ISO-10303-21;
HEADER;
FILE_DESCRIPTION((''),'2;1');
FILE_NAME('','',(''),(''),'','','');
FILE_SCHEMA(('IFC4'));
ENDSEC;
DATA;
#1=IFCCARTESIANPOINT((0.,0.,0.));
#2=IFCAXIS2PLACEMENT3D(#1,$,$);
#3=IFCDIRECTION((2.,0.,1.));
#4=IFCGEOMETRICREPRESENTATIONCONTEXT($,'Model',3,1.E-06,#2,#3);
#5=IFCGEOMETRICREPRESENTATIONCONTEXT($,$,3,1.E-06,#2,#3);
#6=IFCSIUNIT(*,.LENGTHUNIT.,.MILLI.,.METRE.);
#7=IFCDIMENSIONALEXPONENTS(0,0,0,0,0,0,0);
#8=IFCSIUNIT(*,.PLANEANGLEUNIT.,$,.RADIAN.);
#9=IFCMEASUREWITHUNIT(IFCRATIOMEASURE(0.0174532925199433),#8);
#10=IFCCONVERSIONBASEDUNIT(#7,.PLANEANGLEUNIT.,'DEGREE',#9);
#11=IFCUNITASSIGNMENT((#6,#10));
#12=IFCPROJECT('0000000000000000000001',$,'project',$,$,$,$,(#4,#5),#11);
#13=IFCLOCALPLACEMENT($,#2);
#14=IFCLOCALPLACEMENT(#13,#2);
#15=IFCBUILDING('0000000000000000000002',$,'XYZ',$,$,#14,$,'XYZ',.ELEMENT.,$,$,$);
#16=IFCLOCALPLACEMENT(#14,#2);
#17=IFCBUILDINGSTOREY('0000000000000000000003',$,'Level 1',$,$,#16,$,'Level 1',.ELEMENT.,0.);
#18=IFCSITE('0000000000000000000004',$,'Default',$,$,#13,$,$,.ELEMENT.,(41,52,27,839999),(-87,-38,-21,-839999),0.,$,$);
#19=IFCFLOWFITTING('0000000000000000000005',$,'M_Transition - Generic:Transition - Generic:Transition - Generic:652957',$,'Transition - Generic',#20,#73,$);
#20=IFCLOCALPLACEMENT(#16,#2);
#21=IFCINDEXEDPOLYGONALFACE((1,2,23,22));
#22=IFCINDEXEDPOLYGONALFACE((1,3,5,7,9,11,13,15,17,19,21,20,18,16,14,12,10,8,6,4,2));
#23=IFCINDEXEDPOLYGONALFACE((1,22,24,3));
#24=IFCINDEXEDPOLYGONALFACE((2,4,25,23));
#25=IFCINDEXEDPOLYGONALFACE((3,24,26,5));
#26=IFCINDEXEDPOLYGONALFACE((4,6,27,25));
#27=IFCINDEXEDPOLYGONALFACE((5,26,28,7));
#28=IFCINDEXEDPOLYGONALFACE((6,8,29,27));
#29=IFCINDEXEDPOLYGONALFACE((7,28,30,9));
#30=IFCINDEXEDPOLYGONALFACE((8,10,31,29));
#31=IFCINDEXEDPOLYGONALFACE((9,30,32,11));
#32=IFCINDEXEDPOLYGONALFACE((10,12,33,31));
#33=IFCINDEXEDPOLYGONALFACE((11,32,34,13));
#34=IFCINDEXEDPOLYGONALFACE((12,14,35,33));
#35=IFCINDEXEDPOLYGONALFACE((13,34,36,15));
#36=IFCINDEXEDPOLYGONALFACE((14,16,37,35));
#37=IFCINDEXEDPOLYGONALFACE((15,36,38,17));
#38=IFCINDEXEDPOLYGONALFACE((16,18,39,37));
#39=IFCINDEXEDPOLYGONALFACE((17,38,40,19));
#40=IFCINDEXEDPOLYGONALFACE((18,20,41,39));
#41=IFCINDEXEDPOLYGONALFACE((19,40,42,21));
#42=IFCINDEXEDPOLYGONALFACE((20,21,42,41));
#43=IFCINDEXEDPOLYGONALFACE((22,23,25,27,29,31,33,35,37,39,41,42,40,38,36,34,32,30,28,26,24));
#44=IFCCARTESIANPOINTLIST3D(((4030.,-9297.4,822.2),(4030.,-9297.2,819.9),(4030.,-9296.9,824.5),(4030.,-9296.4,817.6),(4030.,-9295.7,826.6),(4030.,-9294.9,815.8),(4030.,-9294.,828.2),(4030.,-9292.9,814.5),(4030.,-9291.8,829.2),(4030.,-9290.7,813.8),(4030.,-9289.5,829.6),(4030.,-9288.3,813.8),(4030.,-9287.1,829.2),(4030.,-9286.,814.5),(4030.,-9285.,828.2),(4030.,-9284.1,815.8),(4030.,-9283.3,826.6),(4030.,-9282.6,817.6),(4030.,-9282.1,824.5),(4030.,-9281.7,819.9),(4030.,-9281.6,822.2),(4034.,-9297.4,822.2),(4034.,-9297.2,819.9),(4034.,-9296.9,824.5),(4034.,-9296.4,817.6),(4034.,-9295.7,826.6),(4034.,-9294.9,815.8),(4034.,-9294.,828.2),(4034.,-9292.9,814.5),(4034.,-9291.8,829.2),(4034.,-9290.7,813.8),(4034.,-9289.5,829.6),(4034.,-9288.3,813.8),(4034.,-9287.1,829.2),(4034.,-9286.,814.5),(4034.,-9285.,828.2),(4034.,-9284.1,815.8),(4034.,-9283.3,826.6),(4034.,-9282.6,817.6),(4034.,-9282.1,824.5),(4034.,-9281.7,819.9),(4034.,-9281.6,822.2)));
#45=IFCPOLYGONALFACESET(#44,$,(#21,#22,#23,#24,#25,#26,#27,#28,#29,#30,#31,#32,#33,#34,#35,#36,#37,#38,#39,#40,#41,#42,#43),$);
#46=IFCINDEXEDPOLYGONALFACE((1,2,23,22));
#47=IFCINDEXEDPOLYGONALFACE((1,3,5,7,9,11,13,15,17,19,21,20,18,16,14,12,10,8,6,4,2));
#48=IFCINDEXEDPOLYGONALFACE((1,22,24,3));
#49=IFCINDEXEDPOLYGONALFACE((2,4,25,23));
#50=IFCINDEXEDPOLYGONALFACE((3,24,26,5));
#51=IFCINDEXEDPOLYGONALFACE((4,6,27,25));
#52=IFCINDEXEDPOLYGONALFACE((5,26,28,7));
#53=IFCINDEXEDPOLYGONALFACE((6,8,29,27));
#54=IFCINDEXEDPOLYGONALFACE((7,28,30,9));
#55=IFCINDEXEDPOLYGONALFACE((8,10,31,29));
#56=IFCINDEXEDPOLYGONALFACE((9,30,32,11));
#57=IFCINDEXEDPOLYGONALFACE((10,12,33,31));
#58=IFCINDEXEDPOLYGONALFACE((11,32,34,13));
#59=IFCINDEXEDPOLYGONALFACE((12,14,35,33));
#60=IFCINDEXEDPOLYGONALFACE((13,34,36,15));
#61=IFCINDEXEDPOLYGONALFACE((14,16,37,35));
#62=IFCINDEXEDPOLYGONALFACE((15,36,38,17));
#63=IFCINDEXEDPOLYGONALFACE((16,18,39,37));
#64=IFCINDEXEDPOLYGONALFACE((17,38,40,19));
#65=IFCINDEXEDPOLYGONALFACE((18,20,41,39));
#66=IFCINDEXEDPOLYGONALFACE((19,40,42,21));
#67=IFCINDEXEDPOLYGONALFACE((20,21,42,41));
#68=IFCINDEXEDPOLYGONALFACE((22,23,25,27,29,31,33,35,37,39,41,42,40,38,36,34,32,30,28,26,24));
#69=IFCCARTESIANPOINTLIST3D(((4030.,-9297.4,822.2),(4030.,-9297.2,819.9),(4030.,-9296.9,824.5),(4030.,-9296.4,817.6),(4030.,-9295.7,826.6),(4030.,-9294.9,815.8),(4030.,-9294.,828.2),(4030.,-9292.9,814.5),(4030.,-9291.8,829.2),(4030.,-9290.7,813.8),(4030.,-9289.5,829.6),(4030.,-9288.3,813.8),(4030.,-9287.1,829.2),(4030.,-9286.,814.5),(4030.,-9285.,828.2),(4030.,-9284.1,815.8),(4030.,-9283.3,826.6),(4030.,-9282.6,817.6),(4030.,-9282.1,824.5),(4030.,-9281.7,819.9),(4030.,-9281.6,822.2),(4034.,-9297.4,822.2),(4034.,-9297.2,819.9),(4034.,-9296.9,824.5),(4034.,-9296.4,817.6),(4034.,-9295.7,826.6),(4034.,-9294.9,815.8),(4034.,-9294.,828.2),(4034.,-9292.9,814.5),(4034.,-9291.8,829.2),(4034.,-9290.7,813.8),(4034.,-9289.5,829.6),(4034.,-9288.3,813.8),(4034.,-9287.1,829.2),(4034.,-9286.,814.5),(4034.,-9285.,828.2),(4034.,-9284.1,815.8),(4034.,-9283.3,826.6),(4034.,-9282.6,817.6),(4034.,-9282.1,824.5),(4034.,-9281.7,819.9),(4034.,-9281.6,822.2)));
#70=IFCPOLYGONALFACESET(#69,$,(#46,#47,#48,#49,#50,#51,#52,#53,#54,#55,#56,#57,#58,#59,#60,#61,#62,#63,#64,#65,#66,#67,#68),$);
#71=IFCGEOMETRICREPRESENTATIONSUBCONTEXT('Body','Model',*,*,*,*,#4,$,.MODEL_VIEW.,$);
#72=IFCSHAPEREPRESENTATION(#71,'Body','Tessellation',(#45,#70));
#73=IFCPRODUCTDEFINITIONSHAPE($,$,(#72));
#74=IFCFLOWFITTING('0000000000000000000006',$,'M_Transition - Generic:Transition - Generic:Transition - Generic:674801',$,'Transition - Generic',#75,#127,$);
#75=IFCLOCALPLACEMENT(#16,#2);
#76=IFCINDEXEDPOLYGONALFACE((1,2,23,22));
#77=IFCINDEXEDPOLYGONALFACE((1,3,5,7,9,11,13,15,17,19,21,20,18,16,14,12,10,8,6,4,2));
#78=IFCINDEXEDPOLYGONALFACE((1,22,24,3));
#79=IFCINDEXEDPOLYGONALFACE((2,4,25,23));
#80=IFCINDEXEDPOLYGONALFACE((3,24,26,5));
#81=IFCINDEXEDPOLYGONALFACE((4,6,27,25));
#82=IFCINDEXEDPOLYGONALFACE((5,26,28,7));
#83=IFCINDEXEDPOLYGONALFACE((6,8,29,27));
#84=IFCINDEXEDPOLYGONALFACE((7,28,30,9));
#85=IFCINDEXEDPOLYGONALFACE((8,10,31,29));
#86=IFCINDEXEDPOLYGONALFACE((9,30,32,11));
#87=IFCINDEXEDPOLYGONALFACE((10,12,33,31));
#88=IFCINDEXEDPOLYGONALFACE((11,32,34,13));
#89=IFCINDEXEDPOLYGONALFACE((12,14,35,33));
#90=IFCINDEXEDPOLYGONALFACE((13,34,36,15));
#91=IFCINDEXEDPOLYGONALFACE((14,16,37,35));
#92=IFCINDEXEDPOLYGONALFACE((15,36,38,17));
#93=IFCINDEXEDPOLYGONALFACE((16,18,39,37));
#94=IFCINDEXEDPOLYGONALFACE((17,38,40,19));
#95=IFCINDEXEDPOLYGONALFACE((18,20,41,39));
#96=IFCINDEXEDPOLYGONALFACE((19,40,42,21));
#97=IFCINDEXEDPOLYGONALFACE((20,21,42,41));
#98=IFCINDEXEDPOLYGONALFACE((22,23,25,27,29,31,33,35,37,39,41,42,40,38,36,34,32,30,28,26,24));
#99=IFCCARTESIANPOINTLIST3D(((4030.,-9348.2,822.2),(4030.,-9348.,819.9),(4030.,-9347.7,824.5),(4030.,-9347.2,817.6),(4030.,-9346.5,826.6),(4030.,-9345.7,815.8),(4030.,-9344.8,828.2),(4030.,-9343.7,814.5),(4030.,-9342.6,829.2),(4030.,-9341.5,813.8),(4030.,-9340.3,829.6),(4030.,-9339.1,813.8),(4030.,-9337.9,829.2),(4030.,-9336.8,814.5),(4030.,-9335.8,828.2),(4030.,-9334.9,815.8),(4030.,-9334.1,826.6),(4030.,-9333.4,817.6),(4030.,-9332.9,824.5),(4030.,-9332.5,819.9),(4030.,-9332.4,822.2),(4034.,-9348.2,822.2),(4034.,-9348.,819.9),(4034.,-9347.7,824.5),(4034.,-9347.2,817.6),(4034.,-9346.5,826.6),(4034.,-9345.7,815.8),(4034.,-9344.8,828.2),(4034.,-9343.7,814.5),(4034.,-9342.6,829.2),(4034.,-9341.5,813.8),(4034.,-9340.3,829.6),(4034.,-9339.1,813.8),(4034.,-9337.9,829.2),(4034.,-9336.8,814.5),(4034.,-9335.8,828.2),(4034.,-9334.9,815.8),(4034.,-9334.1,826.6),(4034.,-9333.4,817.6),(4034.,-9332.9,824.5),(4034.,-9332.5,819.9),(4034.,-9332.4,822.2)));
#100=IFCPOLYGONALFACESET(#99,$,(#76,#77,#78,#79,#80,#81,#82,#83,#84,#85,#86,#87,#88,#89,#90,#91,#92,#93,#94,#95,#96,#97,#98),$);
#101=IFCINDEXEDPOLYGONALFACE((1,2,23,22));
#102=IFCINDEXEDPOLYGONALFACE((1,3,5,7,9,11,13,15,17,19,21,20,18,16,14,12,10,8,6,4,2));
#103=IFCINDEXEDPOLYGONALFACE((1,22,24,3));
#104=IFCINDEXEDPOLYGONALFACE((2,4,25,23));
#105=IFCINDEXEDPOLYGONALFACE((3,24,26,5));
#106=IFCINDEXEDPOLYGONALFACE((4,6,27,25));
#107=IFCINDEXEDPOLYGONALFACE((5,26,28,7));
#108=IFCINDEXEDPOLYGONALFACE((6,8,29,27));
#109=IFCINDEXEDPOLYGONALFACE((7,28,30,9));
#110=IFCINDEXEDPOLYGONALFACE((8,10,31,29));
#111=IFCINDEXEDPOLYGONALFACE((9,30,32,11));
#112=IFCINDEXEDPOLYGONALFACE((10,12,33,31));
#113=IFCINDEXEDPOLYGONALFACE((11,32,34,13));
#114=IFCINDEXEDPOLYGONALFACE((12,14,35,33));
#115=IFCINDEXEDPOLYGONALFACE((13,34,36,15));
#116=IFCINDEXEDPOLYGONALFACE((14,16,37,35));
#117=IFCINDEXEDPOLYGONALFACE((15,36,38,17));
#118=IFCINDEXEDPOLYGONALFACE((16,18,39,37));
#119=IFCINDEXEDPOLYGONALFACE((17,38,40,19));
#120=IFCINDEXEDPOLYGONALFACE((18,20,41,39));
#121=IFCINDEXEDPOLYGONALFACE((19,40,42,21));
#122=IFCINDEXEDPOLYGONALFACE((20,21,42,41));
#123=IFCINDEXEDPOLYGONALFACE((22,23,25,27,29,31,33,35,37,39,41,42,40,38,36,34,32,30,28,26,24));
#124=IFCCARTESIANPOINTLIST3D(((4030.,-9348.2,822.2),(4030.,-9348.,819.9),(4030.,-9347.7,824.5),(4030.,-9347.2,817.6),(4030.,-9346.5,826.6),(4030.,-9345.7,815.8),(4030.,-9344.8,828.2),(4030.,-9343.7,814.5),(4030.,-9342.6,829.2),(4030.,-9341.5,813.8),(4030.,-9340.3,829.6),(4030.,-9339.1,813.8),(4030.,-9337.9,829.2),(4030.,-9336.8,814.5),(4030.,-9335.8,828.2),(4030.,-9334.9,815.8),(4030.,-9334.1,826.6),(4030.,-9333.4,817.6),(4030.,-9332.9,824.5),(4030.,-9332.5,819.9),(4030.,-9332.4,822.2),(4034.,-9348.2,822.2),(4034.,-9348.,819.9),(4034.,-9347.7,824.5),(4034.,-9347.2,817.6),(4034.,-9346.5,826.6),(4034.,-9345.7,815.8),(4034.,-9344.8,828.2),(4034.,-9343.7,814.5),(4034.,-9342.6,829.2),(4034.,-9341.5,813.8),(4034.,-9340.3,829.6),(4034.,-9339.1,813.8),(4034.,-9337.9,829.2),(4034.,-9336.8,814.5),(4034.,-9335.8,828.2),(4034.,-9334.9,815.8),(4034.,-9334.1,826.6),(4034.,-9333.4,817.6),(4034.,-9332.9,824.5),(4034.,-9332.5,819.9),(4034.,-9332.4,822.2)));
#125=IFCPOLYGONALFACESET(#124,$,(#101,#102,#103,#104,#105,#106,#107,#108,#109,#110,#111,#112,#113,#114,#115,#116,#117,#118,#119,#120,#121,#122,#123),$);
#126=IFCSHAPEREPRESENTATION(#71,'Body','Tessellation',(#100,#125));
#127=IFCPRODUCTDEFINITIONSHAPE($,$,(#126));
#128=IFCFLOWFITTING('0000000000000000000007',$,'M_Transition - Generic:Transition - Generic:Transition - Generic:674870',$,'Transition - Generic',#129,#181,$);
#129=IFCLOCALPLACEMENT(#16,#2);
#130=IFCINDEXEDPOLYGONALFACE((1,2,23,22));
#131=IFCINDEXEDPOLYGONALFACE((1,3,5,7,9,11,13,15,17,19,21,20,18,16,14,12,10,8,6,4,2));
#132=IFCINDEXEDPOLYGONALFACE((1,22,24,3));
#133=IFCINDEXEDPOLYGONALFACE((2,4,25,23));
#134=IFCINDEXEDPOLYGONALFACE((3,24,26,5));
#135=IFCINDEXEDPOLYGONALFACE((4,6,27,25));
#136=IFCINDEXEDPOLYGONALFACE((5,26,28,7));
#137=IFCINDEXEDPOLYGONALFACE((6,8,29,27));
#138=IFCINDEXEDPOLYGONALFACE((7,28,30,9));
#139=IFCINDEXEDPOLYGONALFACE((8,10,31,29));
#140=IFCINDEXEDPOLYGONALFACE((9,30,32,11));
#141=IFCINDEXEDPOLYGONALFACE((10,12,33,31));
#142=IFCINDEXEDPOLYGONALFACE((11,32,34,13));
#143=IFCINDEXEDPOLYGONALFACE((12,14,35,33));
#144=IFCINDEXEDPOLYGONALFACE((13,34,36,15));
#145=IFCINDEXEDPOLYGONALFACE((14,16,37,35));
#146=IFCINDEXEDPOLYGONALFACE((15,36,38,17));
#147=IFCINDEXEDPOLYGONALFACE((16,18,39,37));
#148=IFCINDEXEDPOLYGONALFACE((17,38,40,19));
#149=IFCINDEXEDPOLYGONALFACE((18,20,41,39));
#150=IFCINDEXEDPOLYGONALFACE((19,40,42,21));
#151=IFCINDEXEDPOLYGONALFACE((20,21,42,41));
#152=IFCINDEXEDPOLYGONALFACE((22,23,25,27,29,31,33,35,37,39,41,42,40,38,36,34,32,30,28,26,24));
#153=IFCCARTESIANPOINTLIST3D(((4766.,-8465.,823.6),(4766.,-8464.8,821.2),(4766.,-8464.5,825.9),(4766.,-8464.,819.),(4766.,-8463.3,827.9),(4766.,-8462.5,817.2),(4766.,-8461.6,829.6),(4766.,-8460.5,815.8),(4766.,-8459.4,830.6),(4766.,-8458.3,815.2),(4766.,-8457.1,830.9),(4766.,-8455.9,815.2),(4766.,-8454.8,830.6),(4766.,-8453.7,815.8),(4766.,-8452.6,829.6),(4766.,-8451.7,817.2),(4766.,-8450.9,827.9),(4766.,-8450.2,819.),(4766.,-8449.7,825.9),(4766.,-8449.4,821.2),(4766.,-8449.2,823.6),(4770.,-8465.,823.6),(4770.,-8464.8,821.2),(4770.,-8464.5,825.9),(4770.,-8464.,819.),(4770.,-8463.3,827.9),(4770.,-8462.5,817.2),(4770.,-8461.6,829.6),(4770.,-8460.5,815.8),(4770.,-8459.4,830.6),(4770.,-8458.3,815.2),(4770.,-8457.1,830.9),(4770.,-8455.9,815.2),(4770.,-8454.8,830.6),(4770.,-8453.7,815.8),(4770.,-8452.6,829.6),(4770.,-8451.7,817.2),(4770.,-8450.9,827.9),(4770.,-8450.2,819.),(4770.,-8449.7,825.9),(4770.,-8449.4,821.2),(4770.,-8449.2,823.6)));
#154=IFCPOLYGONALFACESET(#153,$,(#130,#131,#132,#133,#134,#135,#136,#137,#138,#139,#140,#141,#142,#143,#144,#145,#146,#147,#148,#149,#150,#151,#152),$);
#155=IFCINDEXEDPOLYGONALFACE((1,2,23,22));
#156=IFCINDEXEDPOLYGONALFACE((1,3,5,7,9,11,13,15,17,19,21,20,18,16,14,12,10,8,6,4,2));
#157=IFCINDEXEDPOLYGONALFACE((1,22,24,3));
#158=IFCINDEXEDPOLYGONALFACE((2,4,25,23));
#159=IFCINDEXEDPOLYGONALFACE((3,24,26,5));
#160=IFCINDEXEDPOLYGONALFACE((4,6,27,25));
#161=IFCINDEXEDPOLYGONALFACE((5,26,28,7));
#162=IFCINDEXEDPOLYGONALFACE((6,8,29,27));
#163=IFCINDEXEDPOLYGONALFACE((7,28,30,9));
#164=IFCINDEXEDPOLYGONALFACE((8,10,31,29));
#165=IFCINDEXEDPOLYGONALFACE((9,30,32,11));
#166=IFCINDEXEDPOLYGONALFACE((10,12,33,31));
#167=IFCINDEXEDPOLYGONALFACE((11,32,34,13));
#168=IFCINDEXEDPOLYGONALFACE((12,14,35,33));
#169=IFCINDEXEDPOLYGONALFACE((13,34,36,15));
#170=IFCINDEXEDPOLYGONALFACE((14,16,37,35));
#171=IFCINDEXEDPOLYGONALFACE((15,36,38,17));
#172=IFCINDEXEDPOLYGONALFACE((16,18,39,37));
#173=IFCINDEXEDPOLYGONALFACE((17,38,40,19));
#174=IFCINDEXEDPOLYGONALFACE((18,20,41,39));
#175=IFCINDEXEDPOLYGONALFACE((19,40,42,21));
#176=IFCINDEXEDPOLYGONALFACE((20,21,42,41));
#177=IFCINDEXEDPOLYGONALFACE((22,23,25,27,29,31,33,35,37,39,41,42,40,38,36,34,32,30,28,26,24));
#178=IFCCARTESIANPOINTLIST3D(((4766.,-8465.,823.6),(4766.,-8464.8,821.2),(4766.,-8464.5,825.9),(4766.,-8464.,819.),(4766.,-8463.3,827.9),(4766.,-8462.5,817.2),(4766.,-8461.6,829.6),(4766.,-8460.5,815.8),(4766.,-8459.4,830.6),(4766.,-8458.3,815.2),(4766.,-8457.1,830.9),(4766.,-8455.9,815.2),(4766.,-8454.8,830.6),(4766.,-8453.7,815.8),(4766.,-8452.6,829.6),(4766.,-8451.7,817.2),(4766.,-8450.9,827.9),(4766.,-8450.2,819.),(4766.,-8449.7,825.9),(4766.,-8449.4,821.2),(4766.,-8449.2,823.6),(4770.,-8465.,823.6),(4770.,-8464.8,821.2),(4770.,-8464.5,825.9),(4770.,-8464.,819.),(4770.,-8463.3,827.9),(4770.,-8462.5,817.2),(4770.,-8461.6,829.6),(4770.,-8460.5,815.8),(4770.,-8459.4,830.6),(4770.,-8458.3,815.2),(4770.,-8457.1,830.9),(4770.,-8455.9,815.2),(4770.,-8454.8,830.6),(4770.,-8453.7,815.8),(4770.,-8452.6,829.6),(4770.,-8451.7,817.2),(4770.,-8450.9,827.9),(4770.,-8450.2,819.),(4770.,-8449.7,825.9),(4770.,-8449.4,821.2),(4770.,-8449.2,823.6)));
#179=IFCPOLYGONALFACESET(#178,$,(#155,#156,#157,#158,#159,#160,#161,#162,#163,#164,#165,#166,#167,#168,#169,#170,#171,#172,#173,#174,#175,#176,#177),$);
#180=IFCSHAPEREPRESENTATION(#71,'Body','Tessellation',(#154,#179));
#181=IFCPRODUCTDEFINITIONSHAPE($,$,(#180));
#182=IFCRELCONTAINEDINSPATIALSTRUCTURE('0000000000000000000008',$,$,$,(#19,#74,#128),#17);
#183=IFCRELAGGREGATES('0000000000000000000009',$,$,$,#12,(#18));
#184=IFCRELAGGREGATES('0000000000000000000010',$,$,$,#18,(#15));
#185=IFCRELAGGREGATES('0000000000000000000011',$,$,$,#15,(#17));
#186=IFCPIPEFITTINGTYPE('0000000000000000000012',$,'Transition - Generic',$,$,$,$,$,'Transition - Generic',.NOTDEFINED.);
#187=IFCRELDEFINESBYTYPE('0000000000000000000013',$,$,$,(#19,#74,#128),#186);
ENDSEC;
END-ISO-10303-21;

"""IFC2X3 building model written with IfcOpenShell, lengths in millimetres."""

from ifc_helpers import new_model, entity, si_unit, converted_unit, direction, frame, frame_2d, origin, place, context, subcontext, project, spatial, circle, extrude, source, transform, mapped, type_object, type_shapes, element, save


model = new_model("IFC2X3")

# Units and contexts
model_context = context("Model", 3, precision=1e-06, world=origin(), true_north=direction((2.0, 0.0, 1.0)))
context_of_model = context(None, 3, precision=1e-06, world=origin(), true_north=direction((2.0, 0.0, 1.0)))
body_context = subcontext(model_context, "Body", "Model", "MODEL_VIEW")
ifc_project = project(units=[si_unit("LENGTHUNIT", "METRE", prefix="MILLI"), converted_unit("PLANEANGLEUNIT", "DEGREE", entity("IfcRatioMeasure", 0.0174532925199433), si_unit("PLANEANGLEUNIT", "RADIAN"), dimensions=[0, 0, 0, 0, 0, 0, 0])], contexts=[model_context, context_of_model])

# Site, building, storey
site_placement = place(None, origin())
site = spatial("IfcSite", under=ifc_project, at=site_placement, Name="Default", CompositionType="ELEMENT", RefLatitude=(41, 52, 27, 839999), RefLongitude=(-87, -38, -21, -839999), RefElevation=0.0)
building_placement = place(site_placement, origin())
building = spatial("IfcBuilding", under=site, at=building_placement, Name="XYZ", LongName="XYZ", CompositionType="ELEMENT")
storey_placement = place(building_placement, origin())
storey = spatial("IfcBuildingStorey", under=building, at=storey_placement, Name="Level 1", LongName="Level 1", CompositionType="ELEMENT", Elevation=0.0)

# Flow fittings
pipe_fitting_type = type_object("IfcPipeFittingType", Name="Transition - Generic", ElementType="Transition - Generic", PredefinedType="NOTDEFINED")
shared_shape = source(origin(), body_context, "Body", "SweptSolid", [
    extrude(circle(Radius=7.9, at=frame_2d((0.0, 0.0), x_axis=(1.0, 0.0))), frame((0.0, 0.0, 0.0), z_axis=(1.0, 0.0, 0.0), x_axis=(0.0, 0.0, 1.0)), (0.0, 0.0, 1.0), 4.0),
    extrude(circle(Radius=7.9, at=frame_2d((0.0, 0.0), x_axis=(1.0, 0.0))), frame((0.0, 0.0, 0.0), z_axis=(1.0, 0.0, 0.0), x_axis=(0.0, 0.0, 1.0)), (0.0, 0.0, 1.0), 4.0),
])
type_shapes(pipe_fitting_type, [shared_shape])
for number, where, z_axis, x_axis, name in (
    (1, (4034.0, -9289.5, 821.6), (0.0, 0.0, 1.0), (-1.0, 0.0, 0.0), "M_Transition - Generic:Transition - Generic:Transition - Generic:652957"),
    (2, (4034.0, -9340.3, 821.6), (0.0, 0.0, 1.0), (-1.0, 0.0, 0.0), "M_Transition - Generic:Transition - Generic:Transition - Generic:674801"),
):
    element("IfcFlowFitting", number, at=place(storey_placement, frame(where, z_axis=z_axis, x_axis=x_axis)), inside=storey, type_object=pipe_fitting_type, Name=name, ObjectType="Transition - Generic", context=body_context, shape_type="MappedRepresentation", body=[
        mapped(shared_shape, transform((0.0, 0.0, 0.0), scale=1.0)),
    ])
for number, where, name in (
    (3, (4766.0, -8457.1, 823.0), "M_Transition - Generic:Transition - Generic:Transition - Generic:674870"),
):
    element("IfcFlowFitting", number, at=place(storey_placement, frame(where)), inside=storey, type_object=pipe_fitting_type, Name=name, ObjectType="Transition - Generic", context=body_context, shape_type="MappedRepresentation", body=[
        mapped(shared_shape, transform((0.0, 0.0, 0.0), scale=1.0)),
    ])

save(model, "model.ifc")
